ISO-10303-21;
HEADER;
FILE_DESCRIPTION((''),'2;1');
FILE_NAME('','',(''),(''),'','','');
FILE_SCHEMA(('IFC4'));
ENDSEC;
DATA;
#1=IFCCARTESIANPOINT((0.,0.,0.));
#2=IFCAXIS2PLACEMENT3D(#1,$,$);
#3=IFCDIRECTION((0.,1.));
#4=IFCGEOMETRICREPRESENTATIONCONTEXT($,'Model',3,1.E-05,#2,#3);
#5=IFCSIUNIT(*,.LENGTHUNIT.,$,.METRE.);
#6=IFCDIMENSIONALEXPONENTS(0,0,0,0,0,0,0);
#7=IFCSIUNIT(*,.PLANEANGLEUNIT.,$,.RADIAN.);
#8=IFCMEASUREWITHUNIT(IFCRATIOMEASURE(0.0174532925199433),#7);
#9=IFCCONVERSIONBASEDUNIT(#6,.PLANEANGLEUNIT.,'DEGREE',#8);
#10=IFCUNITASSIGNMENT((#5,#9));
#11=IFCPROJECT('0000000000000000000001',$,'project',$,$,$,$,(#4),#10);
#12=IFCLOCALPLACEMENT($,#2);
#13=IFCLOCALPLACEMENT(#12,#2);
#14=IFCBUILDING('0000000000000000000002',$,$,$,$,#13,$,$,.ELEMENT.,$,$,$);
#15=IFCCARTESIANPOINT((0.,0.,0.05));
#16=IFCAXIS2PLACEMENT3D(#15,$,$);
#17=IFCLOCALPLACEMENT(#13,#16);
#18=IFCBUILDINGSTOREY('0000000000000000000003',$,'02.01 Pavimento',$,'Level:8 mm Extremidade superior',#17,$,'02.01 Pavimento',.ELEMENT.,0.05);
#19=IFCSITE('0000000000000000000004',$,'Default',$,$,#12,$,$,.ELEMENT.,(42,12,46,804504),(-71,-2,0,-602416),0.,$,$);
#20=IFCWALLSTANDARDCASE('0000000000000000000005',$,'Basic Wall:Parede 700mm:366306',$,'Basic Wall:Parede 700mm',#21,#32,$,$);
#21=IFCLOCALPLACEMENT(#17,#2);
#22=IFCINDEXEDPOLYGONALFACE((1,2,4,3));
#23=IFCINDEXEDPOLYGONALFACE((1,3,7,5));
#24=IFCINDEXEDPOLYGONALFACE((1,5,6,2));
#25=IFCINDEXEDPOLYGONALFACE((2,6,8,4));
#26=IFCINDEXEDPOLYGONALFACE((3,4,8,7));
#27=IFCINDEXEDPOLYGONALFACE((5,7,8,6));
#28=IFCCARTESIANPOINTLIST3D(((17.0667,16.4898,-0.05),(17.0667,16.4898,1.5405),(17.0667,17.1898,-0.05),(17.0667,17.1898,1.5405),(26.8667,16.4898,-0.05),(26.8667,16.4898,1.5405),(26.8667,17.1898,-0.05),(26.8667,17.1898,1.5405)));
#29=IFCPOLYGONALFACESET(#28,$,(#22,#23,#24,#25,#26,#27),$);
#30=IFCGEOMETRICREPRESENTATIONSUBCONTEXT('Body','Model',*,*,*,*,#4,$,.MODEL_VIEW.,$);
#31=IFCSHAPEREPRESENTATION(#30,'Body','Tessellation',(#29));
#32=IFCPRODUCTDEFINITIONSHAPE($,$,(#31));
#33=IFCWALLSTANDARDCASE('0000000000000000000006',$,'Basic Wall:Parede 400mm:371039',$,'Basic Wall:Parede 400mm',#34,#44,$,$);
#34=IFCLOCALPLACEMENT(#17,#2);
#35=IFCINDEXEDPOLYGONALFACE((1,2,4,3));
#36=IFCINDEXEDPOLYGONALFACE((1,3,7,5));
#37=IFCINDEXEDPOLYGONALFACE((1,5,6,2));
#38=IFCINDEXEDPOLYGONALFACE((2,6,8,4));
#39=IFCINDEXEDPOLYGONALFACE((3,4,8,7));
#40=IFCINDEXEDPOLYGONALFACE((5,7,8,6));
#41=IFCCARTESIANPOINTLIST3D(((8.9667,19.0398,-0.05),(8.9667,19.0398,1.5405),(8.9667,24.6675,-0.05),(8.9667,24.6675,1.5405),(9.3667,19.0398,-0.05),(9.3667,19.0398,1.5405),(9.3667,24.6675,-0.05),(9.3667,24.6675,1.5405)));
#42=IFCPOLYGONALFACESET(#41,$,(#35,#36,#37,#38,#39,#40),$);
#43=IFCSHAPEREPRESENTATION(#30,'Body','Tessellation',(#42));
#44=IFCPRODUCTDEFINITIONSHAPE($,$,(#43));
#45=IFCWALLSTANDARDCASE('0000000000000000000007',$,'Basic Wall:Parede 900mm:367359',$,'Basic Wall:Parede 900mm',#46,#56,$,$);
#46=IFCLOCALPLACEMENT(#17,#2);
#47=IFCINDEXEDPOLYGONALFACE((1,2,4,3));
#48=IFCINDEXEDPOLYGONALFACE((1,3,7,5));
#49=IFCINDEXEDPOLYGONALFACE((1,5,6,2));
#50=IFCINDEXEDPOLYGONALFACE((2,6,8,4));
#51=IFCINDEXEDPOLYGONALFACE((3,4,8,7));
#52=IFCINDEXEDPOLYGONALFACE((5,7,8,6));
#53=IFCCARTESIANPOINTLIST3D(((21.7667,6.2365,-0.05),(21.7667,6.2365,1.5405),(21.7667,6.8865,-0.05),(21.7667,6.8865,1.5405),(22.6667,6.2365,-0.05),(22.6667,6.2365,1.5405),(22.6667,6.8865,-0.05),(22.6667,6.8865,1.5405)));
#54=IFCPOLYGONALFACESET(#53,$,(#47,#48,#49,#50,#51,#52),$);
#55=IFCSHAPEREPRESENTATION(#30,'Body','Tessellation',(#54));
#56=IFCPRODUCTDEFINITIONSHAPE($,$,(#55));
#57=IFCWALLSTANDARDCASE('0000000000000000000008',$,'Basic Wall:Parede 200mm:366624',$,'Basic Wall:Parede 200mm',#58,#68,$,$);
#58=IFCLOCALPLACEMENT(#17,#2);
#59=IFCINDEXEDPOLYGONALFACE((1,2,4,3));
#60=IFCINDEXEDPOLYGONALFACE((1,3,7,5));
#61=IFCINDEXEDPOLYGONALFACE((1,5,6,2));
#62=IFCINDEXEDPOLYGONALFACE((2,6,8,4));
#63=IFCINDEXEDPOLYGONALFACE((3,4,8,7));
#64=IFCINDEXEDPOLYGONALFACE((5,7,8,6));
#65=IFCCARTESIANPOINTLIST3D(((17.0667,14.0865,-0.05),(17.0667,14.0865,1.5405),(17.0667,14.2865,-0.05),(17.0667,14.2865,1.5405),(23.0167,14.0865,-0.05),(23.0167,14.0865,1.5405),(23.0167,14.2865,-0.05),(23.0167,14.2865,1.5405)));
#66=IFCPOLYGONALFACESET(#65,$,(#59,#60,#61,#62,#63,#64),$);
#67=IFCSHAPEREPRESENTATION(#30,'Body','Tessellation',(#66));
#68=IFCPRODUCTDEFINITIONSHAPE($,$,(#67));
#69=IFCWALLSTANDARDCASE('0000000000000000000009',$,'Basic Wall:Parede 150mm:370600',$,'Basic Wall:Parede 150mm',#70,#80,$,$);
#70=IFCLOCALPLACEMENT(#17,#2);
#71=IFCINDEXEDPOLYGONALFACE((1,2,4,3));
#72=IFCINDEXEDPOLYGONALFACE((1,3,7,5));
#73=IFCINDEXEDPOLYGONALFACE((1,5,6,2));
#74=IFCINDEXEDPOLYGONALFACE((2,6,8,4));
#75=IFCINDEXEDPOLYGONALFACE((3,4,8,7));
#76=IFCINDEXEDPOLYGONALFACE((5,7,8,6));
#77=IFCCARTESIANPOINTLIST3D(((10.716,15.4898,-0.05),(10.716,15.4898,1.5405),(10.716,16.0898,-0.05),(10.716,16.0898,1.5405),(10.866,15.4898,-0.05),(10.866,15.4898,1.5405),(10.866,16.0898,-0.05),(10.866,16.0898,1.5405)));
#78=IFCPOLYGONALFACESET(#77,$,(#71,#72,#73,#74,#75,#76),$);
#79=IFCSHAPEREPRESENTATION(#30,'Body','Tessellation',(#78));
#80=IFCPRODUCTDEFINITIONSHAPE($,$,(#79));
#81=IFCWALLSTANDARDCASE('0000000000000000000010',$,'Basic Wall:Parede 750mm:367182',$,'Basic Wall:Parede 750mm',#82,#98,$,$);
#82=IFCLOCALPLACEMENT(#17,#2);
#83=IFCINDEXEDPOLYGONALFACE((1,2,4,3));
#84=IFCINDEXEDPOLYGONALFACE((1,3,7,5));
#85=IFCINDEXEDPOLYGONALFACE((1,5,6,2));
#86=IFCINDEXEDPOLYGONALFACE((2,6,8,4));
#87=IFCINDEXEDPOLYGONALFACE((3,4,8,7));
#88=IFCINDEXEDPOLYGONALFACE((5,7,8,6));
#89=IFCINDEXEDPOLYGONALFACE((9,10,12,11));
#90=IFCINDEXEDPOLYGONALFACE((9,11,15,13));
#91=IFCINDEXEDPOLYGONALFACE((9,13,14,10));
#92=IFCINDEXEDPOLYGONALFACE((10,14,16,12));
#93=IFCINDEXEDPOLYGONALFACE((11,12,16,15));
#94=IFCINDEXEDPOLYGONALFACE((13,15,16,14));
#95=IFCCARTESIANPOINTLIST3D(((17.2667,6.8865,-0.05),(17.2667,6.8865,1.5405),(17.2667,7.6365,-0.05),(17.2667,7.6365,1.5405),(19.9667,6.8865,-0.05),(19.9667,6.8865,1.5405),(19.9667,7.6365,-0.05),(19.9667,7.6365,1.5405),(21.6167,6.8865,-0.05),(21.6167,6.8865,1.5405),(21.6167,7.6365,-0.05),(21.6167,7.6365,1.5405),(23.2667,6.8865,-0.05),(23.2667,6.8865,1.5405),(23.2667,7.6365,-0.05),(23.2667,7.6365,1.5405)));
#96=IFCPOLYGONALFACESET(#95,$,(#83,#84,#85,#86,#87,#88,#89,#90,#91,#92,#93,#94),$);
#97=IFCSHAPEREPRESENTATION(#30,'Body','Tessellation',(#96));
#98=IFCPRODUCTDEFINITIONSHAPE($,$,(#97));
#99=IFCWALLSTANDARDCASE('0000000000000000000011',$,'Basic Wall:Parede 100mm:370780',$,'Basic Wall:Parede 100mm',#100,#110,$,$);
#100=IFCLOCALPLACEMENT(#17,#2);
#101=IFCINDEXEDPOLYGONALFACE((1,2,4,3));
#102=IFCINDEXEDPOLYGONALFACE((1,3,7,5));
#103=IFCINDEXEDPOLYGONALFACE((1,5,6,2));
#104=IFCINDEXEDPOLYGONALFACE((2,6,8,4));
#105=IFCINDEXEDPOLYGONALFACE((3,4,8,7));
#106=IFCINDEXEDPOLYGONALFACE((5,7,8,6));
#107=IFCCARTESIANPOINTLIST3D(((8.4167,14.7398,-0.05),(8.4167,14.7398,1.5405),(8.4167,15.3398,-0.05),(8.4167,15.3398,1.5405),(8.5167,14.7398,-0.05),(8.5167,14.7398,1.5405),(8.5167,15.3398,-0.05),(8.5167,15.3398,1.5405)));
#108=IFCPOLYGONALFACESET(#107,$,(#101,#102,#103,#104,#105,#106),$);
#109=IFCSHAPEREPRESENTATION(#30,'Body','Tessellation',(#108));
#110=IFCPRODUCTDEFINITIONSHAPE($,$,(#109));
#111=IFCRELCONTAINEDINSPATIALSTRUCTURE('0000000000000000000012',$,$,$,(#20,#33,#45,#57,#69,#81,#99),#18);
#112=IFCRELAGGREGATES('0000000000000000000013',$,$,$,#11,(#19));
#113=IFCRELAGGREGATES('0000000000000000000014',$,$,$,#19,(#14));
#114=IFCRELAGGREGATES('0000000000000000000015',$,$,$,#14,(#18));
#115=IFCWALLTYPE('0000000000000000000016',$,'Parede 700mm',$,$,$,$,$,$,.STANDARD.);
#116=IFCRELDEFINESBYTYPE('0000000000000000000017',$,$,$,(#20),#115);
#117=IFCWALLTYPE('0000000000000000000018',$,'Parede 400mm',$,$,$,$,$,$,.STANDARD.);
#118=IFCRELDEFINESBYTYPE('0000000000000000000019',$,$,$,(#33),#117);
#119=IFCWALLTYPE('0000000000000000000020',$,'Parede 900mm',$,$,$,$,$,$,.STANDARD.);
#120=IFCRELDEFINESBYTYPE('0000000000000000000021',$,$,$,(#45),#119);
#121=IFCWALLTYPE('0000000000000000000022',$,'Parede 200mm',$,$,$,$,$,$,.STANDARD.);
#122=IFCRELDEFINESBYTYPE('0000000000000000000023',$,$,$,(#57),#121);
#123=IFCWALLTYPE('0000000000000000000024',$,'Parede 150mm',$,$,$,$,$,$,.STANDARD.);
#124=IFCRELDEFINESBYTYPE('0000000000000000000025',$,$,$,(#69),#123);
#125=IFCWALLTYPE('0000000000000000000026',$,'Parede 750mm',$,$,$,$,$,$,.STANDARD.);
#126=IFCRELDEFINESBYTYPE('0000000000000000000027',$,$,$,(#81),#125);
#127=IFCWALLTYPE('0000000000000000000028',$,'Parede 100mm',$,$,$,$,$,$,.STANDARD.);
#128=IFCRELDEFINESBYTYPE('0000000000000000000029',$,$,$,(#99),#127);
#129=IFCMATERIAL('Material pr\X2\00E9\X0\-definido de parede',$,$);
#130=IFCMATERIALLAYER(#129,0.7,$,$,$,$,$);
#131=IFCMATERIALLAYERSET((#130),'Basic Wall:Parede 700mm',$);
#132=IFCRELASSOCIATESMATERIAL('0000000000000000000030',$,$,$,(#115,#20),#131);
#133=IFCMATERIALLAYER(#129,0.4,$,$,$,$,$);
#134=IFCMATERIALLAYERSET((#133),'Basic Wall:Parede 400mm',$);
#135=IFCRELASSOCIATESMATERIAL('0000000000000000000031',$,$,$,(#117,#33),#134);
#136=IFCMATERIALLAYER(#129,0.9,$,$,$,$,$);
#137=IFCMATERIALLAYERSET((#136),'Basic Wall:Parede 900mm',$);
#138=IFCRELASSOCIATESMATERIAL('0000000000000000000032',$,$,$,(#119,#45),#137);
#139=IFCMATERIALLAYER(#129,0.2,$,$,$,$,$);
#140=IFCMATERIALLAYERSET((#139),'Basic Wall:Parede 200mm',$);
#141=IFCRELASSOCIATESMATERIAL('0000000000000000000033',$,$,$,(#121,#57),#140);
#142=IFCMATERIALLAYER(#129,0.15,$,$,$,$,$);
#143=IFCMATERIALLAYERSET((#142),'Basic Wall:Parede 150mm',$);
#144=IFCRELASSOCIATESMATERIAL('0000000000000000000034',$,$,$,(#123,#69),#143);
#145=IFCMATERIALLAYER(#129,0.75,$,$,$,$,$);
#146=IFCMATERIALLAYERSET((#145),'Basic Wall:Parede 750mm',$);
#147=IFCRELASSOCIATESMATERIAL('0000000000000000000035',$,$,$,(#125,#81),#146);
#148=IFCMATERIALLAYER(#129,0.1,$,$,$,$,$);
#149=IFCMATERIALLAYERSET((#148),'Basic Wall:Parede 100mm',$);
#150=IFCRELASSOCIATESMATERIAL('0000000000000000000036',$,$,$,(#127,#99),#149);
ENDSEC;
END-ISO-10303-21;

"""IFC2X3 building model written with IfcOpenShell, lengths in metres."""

from ifc_helpers import new_model, entity, si_unit, converted_unit, direction, frame, frame_2d, origin, place, context, subcontext, project, spatial, rectangle, extrude, clip, halfspace, material, layer, layer_set, layer_usage, type_object, element, save


model = new_model("IFC2X3")

# Units and contexts
model_context = context("Model", 3, precision=1e-05, world=origin(), true_north=direction((0.0, 1.0)))
body_context = subcontext(model_context, "Body", "Model", "MODEL_VIEW")
ifc_project = project(units=[si_unit("LENGTHUNIT", "METRE"), converted_unit("PLANEANGLEUNIT", "DEGREE", entity("IfcRatioMeasure", 0.0174532925199433), si_unit("PLANEANGLEUNIT", "RADIAN"), dimensions=[0, 0, 0, 0, 0, 0, 0])], contexts=[model_context])

# Site, building, storey
site_placement = place(None, origin())
site = spatial("IfcSite", under=ifc_project, at=site_placement, Name="Default", CompositionType="ELEMENT", RefLatitude=(42, 12, 46, 804504), RefLongitude=(-71, -2, 0, -602416), RefElevation=0.0)
building_placement = place(site_placement, origin())
building = spatial("IfcBuilding", under=site, at=building_placement, CompositionType="ELEMENT")
storey_placement = place(building_placement, frame((0.0, 0.0, 0.05)))
storey = spatial("IfcBuildingStorey", under=building, at=storey_placement, Name="02.01 Pavimento", ObjectType="Level:8 mm Extremidade superior", LongName="02.01 Pavimento", CompositionType="ELEMENT", Elevation=0.05)

# Shared definitions
ifc_material = material(Name="Material pré-definido de parede")
ifc_layer_1 = layer(ifc_material, 0.7)
ifc_layer_set_1 = layer_set([ifc_layer_1], Name="Basic Wall:Parede 700mm")
wall_type_1 = type_object("IfcWallType", Name="Parede 700mm", PredefinedType="STANDARD", material=ifc_layer_set_1)

# Wall
ifc_layer_usage_1 = layer_usage(ifc_layer_set_1, "AXIS2", "NEGATIVE", 0.35)
wall_1_placement = place(storey_placement, frame((17.0667, 16.8398, -0.05)))
element("IfcWallStandardCase", 1, at=wall_1_placement, inside=storey, type_object=wall_type_1, material=ifc_layer_usage_1, Name="Basic Wall:Parede 700mm:366306", ObjectType="Basic Wall:Parede 700mm", context=body_context, shape_type="Clipping", body=[
    clip(extrude(rectangle(XDim=9.8, YDim=0.7, at=frame_2d((4.9, 0.0), x_axis=(-1.0, 0.0))), origin(), (0.0, 0.0, 1.0), 1.5905), halfspace(frame((0.0, 0.0, -0.05)), True)),
])

# Wall
ifc_layer_2 = layer(ifc_material, 0.4)
ifc_layer_set_2 = layer_set([ifc_layer_2], Name="Basic Wall:Parede 400mm")
ifc_layer_usage_2 = layer_usage(ifc_layer_set_2, "AXIS2", "NEGATIVE", 0.2)
wall_type_2 = type_object("IfcWallType", Name="Parede 400mm", PredefinedType="STANDARD", material=ifc_layer_set_2)
wall_2_placement = place(storey_placement, frame((9.1667, 19.0398, -0.05), z_axis=(0.0, 0.0, 1.0), x_axis=(0.0, 1.0, 0.0)))
element("IfcWallStandardCase", 2, at=wall_2_placement, inside=storey, type_object=wall_type_2, material=ifc_layer_usage_2, Name="Basic Wall:Parede 400mm:371039", ObjectType="Basic Wall:Parede 400mm", context=body_context, shape_type="Clipping", body=[
    clip(extrude(rectangle(XDim=5.6276, YDim=0.4, at=frame_2d((2.8138, 0.0), x_axis=(-1.0, 0.0))), origin(), (0.0, 0.0, 1.0), 1.5905), halfspace(frame((0.0, 0.0, -0.05)), True)),
])

# Shared definitions
ifc_layer_3 = layer(ifc_material, 0.9)
ifc_layer_set_3 = layer_set([ifc_layer_3], Name="Basic Wall:Parede 900mm")
wall_type_3 = type_object("IfcWallType", Name="Parede 900mm", PredefinedType="STANDARD", material=ifc_layer_set_3)

# Walls
ifc_layer_usage_3 = layer_usage(ifc_layer_set_3, "AXIS2", "POSITIVE", -0.45)
wall_3_placement = place(storey_placement, frame((22.2167, 6.2365, -0.05), z_axis=(0.0, 0.0, 1.0), x_axis=(0.0, 1.0, 0.0)))
element("IfcWallStandardCase", 3, at=wall_3_placement, inside=storey, type_object=wall_type_3, material=ifc_layer_usage_3, Name="Basic Wall:Parede 900mm:367359", ObjectType="Basic Wall:Parede 900mm", context=body_context, shape_type="Clipping", body=[
    clip(extrude(rectangle(XDim=0.65, YDim=0.9, at=frame_2d((0.325, 0.0), x_axis=(-1.0, 0.0))), origin(), (0.0, 0.0, 1.0), 1.5905), halfspace(frame((0.0, 0.0, -0.05)), True)),
])
ifc_layer_4 = layer(ifc_material, 0.2)
ifc_layer_set_4 = layer_set([ifc_layer_4], Name="Basic Wall:Parede 200mm")
ifc_layer_usage_4 = layer_usage(ifc_layer_set_4, "AXIS2", "NEGATIVE", 0.1)
wall_type_4 = type_object("IfcWallType", Name="Parede 200mm", PredefinedType="STANDARD", material=ifc_layer_set_4)
wall_4_placement = place(storey_placement, frame((17.0667, 14.1865, -0.05)))
element("IfcWallStandardCase", 4, at=wall_4_placement, inside=storey, type_object=wall_type_4, material=ifc_layer_usage_4, Name="Basic Wall:Parede 200mm:366624", ObjectType="Basic Wall:Parede 200mm", context=body_context, shape_type="Clipping", body=[
    clip(extrude(rectangle(XDim=5.95, YDim=0.2, at=frame_2d((2.975, 0.0), x_axis=(-1.0, 0.0))), origin(), (0.0, 0.0, 1.0), 1.5905), halfspace(frame((0.0, 0.0, -0.05)), True)),
])
ifc_layer_5 = layer(ifc_material, 0.15)
ifc_layer_set_5 = layer_set([ifc_layer_5], Name="Basic Wall:Parede 150mm")
ifc_layer_usage_5 = layer_usage(ifc_layer_set_5, "AXIS2", "POSITIVE", -0.075)
wall_type_5 = type_object("IfcWallType", Name="Parede 150mm", PredefinedType="STANDARD", material=ifc_layer_set_5)
wall_5_placement = place(storey_placement, frame((10.791, 16.0898, -0.05), z_axis=(0.0, 0.0, 1.0), x_axis=(0.0, -1.0, 0.0)))
element("IfcWallStandardCase", 5, at=wall_5_placement, inside=storey, type_object=wall_type_5, material=ifc_layer_usage_5, Name="Basic Wall:Parede 150mm:370600", ObjectType="Basic Wall:Parede 150mm", context=body_context, shape_type="Clipping", body=[
    clip(extrude(rectangle(XDim=0.6, YDim=0.15, at=frame_2d((0.3, 0.0), x_axis=(-1.0, 0.0))), origin(), (0.0, 0.0, 1.0), 1.5905), halfspace(frame((0.0, 0.0, -0.05)), True)),
])

# Wall, opening
ifc_layer_6 = layer(ifc_material, 0.75)
ifc_layer_set_6 = layer_set([ifc_layer_6], Name="Basic Wall:Parede 750mm")
ifc_layer_usage_6 = layer_usage(ifc_layer_set_6, "AXIS2", "NEGATIVE", 0.375)
wall_type_6 = type_object("IfcWallType", Name="Parede 750mm", PredefinedType="STANDARD", material=ifc_layer_set_6)
wall_6_placement = place(storey_placement, frame((17.2667, 7.2615, -0.05)))
wall_6 = element("IfcWallStandardCase", 6, at=wall_6_placement, inside=storey, type_object=wall_type_6, material=ifc_layer_usage_6, Name="Basic Wall:Parede 750mm:367182", ObjectType="Basic Wall:Parede 750mm", context=body_context, shape_type="Clipping", body=[
    clip(extrude(rectangle(XDim=6.0, YDim=0.75, at=frame_2d((3.0, 0.0), x_axis=(-1.0, 0.0))), origin(), (0.0, 0.0, 1.0), 1.5905), halfspace(frame((0.0, 0.0, -0.05)), True)),
])
opening_1_placement = place(wall_6_placement, frame((2.7, -1.149, 0.0)))
element("IfcOpeningElement", 7, at=opening_1_placement, cuts=wall_6, ObjectType="Opening", context=body_context, shape_type="SweptSolid", body=[
    extrude(rectangle(XDim=3.4, YDim=1.65, at=frame_2d((0.0, 0.0), x_axis=(0.0, 1.0))), frame((0.825, 0.0, 1.7), z_axis=(0.0, 1.0, 0.0), x_axis=(-1.0, 0.0, 0.0)), (0.0, 0.0, 1.0), 3.048),
])

# Wall
ifc_layer_7 = layer(ifc_material, 0.1)
ifc_layer_set_7 = layer_set([ifc_layer_7], Name="Basic Wall:Parede 100mm")
ifc_layer_usage_7 = layer_usage(ifc_layer_set_7, "AXIS2", "POSITIVE", -0.05)
wall_type_7 = type_object("IfcWallType", Name="Parede 100mm", PredefinedType="STANDARD", material=ifc_layer_set_7)
wall_7_placement = place(storey_placement, frame((8.4667, 14.7398, -0.05), z_axis=(0.0, 0.0, 1.0), x_axis=(0.0, 1.0, 0.0)))
element("IfcWallStandardCase", 8, at=wall_7_placement, inside=storey, type_object=wall_type_7, material=ifc_layer_usage_7, Name="Basic Wall:Parede 100mm:370780", ObjectType="Basic Wall:Parede 100mm", context=body_context, shape_type="Clipping", body=[
    clip(extrude(rectangle(XDim=0.6, YDim=0.1, at=frame_2d((0.3, 0.0), x_axis=(-1.0, 0.0))), origin(), (0.0, 0.0, 1.0), 1.5905), halfspace(frame((0.0, 0.0, -0.05)), True)),
])

save(model, "model.ifc")
